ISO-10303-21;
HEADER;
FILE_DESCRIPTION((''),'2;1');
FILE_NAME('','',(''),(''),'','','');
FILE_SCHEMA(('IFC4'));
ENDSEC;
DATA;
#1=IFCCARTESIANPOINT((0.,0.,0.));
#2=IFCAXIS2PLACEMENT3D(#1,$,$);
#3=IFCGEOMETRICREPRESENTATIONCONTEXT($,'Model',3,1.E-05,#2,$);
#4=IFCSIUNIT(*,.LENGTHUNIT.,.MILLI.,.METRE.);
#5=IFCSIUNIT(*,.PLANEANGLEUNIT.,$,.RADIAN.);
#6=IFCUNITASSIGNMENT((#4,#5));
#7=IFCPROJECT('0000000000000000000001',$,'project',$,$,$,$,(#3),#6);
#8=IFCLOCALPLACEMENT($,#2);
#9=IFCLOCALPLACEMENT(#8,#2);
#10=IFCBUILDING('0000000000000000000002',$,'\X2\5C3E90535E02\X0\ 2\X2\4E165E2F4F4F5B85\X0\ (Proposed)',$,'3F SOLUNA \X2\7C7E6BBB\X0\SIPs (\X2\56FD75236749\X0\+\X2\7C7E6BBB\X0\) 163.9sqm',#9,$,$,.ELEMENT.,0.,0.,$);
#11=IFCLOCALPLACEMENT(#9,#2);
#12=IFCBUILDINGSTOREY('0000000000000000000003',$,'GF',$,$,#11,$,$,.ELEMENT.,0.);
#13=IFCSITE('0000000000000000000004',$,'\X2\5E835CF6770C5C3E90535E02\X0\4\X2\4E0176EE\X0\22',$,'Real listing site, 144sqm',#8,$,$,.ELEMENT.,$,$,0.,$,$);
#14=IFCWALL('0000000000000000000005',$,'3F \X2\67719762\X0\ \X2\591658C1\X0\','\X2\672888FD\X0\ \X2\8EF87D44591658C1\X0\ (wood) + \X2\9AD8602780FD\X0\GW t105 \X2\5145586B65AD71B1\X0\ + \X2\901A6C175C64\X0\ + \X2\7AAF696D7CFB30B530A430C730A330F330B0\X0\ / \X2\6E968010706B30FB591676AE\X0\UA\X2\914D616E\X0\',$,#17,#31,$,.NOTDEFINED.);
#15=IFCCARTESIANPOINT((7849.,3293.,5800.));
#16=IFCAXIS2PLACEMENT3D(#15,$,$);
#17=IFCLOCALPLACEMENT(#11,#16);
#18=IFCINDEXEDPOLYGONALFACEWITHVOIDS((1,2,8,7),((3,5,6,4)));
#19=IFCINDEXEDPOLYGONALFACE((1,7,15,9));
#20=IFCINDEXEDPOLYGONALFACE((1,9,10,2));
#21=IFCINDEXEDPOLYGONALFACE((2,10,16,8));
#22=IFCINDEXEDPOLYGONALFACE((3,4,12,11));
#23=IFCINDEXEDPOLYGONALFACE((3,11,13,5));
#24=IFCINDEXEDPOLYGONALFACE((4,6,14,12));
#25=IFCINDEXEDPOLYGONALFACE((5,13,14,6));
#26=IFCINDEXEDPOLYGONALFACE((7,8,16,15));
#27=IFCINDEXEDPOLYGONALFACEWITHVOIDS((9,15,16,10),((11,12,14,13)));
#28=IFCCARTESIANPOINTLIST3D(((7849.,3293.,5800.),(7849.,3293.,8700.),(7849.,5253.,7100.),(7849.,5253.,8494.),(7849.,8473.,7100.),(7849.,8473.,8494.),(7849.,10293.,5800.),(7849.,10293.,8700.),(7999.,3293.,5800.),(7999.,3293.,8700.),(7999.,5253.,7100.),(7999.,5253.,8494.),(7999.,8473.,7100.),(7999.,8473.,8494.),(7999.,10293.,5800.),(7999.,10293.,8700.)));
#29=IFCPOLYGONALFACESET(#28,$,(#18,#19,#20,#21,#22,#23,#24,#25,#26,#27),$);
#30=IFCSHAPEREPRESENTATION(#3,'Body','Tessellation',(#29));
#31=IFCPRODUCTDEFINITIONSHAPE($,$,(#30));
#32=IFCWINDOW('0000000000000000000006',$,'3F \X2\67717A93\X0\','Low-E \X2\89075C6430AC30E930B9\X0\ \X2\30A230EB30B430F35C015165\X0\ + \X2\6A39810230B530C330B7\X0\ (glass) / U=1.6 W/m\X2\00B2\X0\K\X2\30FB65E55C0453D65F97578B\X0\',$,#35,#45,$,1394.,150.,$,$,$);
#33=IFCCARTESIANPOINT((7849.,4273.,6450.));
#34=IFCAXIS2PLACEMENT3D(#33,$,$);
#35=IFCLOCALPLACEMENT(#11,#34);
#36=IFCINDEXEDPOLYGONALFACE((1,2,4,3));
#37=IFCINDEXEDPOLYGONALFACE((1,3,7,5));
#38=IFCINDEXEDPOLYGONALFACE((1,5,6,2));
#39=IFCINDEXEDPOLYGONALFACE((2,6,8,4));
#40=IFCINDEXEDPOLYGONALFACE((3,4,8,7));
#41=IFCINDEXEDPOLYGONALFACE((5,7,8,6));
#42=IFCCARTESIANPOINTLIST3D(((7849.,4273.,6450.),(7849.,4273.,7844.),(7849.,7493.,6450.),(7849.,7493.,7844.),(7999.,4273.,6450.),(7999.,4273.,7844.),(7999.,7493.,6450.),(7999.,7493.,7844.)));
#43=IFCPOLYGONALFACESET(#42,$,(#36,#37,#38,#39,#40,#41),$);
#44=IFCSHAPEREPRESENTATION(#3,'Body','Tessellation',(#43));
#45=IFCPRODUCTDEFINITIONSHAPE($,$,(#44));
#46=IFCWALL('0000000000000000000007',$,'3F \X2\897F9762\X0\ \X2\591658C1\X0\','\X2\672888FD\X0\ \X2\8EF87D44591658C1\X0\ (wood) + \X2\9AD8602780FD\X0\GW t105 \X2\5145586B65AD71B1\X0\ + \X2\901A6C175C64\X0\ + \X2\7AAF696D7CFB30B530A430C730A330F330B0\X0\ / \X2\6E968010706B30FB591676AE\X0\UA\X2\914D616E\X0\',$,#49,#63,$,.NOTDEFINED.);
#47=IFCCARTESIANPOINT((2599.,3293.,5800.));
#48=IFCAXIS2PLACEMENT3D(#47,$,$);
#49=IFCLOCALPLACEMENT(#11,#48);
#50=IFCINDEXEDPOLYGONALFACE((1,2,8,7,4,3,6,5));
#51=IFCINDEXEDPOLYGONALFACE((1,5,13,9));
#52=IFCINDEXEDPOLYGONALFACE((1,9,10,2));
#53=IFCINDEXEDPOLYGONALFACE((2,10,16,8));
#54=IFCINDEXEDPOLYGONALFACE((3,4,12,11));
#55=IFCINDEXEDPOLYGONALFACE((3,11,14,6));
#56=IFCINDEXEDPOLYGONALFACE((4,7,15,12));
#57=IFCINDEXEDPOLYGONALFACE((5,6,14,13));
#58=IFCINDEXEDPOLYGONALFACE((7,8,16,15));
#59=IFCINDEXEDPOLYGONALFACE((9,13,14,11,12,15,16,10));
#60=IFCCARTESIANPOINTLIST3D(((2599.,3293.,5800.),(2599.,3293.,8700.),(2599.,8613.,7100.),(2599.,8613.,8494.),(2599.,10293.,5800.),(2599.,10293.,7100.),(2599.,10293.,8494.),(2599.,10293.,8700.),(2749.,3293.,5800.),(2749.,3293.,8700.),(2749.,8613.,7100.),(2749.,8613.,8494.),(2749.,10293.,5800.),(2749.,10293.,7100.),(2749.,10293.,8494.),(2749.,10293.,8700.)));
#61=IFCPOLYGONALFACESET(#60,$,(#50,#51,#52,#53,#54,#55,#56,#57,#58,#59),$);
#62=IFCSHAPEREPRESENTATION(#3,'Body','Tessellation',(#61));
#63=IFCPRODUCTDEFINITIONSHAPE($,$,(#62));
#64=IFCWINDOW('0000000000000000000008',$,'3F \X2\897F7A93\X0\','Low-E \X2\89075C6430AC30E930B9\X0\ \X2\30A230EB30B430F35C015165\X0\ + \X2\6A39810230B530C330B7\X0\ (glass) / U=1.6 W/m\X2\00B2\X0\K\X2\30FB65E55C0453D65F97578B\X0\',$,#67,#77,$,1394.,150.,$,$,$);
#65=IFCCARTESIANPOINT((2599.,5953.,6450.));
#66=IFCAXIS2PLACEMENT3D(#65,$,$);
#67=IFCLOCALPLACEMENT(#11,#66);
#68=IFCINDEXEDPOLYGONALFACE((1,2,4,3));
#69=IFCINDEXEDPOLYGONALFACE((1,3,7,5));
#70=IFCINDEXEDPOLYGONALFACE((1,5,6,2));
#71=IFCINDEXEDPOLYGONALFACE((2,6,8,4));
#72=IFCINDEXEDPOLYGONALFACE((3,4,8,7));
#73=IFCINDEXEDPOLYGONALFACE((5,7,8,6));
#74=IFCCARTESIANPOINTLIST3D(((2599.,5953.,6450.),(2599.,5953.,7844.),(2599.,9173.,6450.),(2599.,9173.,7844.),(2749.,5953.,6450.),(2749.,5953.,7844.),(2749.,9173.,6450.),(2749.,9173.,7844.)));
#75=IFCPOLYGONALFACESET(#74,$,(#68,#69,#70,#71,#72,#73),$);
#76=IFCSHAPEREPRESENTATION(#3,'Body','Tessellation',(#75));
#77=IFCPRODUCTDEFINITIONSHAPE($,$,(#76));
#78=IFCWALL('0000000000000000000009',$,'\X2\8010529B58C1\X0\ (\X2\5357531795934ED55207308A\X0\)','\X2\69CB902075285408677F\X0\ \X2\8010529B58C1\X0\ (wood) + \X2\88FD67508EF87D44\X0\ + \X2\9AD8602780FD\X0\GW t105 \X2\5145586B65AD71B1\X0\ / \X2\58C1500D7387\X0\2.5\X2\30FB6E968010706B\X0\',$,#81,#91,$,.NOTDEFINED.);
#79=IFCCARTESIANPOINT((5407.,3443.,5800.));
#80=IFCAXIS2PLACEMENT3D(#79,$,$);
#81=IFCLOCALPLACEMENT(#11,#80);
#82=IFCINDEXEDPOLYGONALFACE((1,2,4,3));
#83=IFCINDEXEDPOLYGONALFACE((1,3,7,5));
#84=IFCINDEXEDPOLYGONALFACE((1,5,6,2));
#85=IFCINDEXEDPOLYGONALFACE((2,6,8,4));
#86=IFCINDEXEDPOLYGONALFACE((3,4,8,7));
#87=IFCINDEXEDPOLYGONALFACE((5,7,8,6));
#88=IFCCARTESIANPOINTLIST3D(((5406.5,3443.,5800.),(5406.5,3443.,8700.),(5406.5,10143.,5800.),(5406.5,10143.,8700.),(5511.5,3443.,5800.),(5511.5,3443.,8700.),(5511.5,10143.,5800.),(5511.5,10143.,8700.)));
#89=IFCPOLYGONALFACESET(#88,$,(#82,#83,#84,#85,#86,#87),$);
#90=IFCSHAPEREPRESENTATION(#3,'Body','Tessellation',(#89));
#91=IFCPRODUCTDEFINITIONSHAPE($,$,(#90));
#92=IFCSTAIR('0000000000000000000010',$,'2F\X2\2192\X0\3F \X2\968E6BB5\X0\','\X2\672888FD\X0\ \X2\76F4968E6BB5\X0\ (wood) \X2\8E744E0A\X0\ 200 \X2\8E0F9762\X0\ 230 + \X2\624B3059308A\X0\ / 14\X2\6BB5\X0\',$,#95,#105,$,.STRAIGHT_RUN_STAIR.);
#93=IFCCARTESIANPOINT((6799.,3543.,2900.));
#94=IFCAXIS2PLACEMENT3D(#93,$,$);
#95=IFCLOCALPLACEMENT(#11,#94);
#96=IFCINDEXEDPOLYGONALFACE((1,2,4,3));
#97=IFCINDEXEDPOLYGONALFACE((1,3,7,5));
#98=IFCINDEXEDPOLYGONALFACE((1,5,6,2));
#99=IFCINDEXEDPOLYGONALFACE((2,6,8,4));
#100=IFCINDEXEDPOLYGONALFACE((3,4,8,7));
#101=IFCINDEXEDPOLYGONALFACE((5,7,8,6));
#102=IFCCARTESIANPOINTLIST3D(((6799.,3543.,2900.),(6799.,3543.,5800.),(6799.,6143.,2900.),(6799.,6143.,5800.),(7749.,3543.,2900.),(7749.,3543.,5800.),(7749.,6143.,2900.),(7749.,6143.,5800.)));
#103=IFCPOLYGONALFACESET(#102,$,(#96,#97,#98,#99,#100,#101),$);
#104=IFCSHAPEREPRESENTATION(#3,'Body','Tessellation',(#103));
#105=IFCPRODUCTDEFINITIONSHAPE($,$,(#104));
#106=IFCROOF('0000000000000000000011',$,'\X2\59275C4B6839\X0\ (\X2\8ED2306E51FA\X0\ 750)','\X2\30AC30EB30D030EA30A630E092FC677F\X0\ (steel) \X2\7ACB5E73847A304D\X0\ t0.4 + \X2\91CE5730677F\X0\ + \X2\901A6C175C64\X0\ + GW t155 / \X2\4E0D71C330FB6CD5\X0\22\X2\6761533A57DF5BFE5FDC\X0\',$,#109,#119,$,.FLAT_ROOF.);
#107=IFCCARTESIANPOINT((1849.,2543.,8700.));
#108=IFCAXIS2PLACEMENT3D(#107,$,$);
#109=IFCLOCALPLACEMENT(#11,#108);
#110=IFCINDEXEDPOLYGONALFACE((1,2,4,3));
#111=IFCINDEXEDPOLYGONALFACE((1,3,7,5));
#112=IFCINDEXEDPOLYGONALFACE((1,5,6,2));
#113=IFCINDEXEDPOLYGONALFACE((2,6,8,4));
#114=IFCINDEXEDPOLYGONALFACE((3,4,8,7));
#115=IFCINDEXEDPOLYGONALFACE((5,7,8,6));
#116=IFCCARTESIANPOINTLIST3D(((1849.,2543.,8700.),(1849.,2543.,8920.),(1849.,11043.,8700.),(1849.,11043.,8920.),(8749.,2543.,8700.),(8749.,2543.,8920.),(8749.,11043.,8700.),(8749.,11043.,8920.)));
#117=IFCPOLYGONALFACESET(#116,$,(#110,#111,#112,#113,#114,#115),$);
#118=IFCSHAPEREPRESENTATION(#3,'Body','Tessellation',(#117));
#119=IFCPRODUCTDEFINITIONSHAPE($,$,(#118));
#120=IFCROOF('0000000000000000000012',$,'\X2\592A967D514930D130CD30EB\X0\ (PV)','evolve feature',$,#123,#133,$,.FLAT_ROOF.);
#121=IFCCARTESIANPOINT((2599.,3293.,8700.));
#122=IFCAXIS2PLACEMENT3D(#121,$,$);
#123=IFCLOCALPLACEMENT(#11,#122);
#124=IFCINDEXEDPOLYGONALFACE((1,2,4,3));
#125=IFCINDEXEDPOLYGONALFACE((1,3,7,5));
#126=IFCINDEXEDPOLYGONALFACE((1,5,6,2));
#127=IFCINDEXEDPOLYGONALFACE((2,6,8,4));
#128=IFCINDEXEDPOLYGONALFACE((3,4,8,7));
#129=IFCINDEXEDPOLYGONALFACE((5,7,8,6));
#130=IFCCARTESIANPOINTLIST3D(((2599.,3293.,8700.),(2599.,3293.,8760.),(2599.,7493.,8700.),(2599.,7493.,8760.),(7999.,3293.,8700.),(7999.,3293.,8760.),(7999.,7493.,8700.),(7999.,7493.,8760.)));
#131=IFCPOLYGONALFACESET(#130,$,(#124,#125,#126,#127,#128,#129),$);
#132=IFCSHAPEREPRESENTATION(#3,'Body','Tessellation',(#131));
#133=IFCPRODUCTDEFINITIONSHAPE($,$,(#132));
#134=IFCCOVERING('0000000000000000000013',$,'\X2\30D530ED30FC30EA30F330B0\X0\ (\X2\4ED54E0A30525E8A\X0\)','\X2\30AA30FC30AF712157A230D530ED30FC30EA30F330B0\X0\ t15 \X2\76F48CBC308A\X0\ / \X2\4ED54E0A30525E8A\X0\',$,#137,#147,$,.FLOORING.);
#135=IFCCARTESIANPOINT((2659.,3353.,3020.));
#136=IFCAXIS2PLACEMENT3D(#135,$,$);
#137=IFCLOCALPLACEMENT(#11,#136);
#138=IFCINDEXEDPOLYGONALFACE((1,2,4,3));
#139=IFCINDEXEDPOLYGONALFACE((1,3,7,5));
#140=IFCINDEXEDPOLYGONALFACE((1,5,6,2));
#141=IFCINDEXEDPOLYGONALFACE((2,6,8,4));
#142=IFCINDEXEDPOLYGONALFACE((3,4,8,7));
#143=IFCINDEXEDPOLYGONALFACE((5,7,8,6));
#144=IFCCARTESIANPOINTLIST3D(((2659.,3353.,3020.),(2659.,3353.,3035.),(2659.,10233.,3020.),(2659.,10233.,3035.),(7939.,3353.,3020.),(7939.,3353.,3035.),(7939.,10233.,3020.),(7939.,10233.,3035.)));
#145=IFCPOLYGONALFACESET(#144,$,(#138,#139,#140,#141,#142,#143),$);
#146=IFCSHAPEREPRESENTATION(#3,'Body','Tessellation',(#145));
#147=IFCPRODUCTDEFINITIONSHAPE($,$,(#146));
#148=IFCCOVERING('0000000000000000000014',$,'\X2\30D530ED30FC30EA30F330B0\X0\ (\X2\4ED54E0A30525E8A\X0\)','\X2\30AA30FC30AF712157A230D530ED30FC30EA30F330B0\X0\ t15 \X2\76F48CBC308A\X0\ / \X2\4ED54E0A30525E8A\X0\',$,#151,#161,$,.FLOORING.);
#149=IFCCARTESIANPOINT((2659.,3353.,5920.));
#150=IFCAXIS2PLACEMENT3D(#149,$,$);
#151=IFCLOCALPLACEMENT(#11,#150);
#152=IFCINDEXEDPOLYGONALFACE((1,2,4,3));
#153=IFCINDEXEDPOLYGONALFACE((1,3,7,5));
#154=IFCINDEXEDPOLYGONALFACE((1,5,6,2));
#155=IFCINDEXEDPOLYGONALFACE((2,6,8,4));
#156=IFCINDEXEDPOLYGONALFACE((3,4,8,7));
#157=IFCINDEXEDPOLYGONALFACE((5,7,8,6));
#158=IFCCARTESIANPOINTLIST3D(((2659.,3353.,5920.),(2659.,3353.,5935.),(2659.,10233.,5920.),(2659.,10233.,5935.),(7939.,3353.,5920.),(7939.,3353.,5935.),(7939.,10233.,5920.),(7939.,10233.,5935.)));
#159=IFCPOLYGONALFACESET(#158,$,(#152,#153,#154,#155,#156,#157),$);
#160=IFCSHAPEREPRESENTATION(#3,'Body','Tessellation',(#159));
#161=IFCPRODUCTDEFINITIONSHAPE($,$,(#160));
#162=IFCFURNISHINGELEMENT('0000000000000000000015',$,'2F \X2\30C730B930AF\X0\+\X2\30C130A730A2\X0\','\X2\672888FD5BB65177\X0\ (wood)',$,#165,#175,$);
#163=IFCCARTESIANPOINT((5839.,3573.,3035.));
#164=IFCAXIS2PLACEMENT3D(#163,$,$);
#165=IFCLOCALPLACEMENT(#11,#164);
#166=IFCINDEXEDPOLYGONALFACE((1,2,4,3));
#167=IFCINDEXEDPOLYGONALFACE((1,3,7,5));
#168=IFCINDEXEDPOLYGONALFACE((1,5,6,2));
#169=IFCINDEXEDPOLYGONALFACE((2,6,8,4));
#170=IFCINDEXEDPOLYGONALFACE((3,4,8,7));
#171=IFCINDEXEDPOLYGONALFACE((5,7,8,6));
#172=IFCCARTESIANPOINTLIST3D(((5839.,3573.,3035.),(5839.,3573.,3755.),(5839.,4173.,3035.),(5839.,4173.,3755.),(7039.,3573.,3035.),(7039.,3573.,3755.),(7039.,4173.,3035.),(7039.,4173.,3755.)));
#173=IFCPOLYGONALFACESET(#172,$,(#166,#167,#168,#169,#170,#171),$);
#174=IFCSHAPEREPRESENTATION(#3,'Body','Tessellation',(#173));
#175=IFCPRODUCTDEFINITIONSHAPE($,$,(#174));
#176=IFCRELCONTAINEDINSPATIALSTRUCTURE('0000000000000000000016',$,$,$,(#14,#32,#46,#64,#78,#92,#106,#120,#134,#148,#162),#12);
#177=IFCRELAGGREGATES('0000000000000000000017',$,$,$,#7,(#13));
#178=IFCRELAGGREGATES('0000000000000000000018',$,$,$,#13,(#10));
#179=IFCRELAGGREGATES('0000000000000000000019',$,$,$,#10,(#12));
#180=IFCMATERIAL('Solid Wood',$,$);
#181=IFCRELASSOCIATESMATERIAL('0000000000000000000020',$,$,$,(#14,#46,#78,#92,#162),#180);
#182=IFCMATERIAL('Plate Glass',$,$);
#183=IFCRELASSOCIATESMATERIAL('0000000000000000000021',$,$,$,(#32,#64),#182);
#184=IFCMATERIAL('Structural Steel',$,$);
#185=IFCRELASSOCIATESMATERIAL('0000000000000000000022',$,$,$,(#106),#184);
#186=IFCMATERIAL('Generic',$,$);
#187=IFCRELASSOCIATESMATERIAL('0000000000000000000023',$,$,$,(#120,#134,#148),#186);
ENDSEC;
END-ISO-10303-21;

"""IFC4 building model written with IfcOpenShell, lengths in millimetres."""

from ifc_helpers import new_model, si_unit, frame, frame_2d, origin, place, context, project, spatial, rectangle, extrude, material, element, fill, save


model = new_model("IFC4")

# Units and contexts
model_context = context("Model", 3, precision=1e-05, world=origin())
ifc_project = project(units=[si_unit("LENGTHUNIT", "METRE", prefix="MILLI"), si_unit("PLANEANGLEUNIT", "RADIAN")], contexts=[model_context])

# Site, building, storey
site_placement = place(None, origin())
site = spatial("IfcSite", under=ifc_project, at=site_placement, Name="広島県尾道市4丁目22", ObjectType="Real listing site, 144sqm", CompositionType="ELEMENT", RefElevation=0.0)
building_placement = place(site_placement, origin())
building = spatial("IfcBuilding", under=site, at=building_placement, Name="尾道市 2世帯住宅 (Proposed)", ObjectType="3F SOLUNA 籾殻SIPs (国産杉+籾殻) 163.9sqm", CompositionType="ELEMENT", ElevationOfRefHeight=0.0, ElevationOfTerrain=0.0)
storey_placement = place(building_placement, origin())
storey = spatial("IfcBuildingStorey", under=building, at=storey_placement, Name="GF", CompositionType="ELEMENT", Elevation=0.0)

# Shared definitions
ifc_material_1 = material(Name="Solid Wood")

# Shared definitions
ifc_material_2 = material(Name="Plate Glass")

# Shared definitions
ifc_material_3 = material(Name="Generic")

# Walls, openings, windows
wall_1_placement = place(storey_placement, frame((7849.0, 3293.0, 5800.0)))
wall_1 = element("IfcWall", 1, at=wall_1_placement, inside=storey, material=ifc_material_1, Name="3F 東面 外壁", Description="木製 軸組外壁 (wood) + 高性能GW t105 充填断熱 + 通気層 + 窯業系サイディング / 準耐火・外皮UA配慮", PredefinedType="NOTDEFINED", context=model_context, shape_type="SweptSolid", body=[
    extrude(rectangle(XDim=150.0, YDim=7000.0, at=frame_2d((75.0, 3500.0))), frame((7849.0, 3293.0, 5800.0)), (0.0, 0.0, 1.0), 2900.0),
])
opening_1_placement = place(storey_placement, frame((7849.0, 4273.0, 6450.0)))
opening_1 = element("IfcOpeningElement", 2, at=opening_1_placement, cuts=wall_1, PredefinedType="NOTDEFINED", context=model_context, shape_type="SweptSolid", body=[
    extrude(rectangle(XDim=150.0, YDim=3220.0, at=frame_2d((75.0, 1610.0))), frame((7849.0, 4273.0, 6450.0)), (0.0, 0.0, 1.0), 1394.0),
])
window_1_placement = place(storey_placement, frame((7849.0, 4273.0, 6450.0)))
window_1 = element("IfcWindow", 3, at=window_1_placement, inside=storey, material=ifc_material_2, Name="3F 東窓", Description="Low-E 複層ガラス アルゴン封入 + 樹脂サッシ (glass) / U=1.6 W/m²K・日射取得型", OverallHeight=1394.0, OverallWidth=150.0, context=model_context, shape_type="SweptSolid", body=[
    extrude(rectangle(XDim=150.0, YDim=3220.0, at=frame_2d((75.0, 1610.0))), frame((7849.0, 4273.0, 6450.0)), (0.0, 0.0, 1.0), 1394.0),
])
fill(opening_1, window_1)
wall_2_placement = place(storey_placement, frame((2599.0, 3293.0, 5800.0)))
wall_2 = element("IfcWall", 4, at=wall_2_placement, inside=storey, material=ifc_material_1, Name="3F 西面 外壁", Description="木製 軸組外壁 (wood) + 高性能GW t105 充填断熱 + 通気層 + 窯業系サイディング / 準耐火・外皮UA配慮", PredefinedType="NOTDEFINED", context=model_context, shape_type="SweptSolid", body=[
    extrude(rectangle(XDim=150.0, YDim=7000.0, at=frame_2d((75.0, 3500.0))), frame((2599.0, 3293.0, 5800.0)), (0.0, 0.0, 1.0), 2900.0),
])
opening_2_placement = place(storey_placement, frame((2599.0, 5953.0, 6450.0)))
opening_2 = element("IfcOpeningElement", 5, at=opening_2_placement, cuts=wall_2, PredefinedType="NOTDEFINED", context=model_context, shape_type="SweptSolid", body=[
    extrude(rectangle(XDim=150.0, YDim=3220.0, at=frame_2d((75.0, 1610.0))), frame((2599.0, 5953.0, 6450.0)), (0.0, 0.0, 1.0), 1394.0),
])
window_2_placement = place(storey_placement, frame((2599.0, 5953.0, 6450.0)))
window_2 = element("IfcWindow", 6, at=window_2_placement, inside=storey, material=ifc_material_2, Name="3F 西窓", Description="Low-E 複層ガラス アルゴン封入 + 樹脂サッシ (glass) / U=1.6 W/m²K・日射取得型", OverallHeight=1394.0, OverallWidth=150.0, context=model_context, shape_type="SweptSolid", body=[
    extrude(rectangle(XDim=150.0, YDim=3220.0, at=frame_2d((75.0, 1610.0))), frame((2599.0, 5953.0, 6450.0)), (0.0, 0.0, 1.0), 1394.0),
])
fill(opening_2, window_2)

# Wall
wall_3_placement = place(storey_placement, frame((5407.0, 3443.0, 5800.0)))
element("IfcWall", 7, at=wall_3_placement, inside=storey, material=ifc_material_1, Name="耐力壁 (南北間仕切り)", Description="構造用合板 耐力壁 (wood) + 製材軸組 + 高性能GW t105 充填断熱 / 壁倍率2.5・準耐火", PredefinedType="NOTDEFINED", context=model_context, shape_type="SweptSolid", body=[
    extrude(rectangle(XDim=105.0, YDim=6700.0, at=frame_2d((52.0, 3350.0))), frame((5407.0, 3443.0, 5800.0)), (0.0, 0.0, 1.0), 2900.0),
])

# Stair
stair_placement = place(storey_placement, frame((6799.0, 3543.0, 2900.0)))
element("IfcStair", 8, at=stair_placement, inside=storey, material=ifc_material_1, Name="2F→3F 階段", Description="木製 直階段 (wood) 蹴上 200 踏面 230 + 手すり / 14段", PredefinedType="STRAIGHT_RUN_STAIR", context=model_context, shape_type="SweptSolid", body=[
    extrude(rectangle(XDim=950.0, YDim=2600.0, at=frame_2d((475.0, 1300.0))), frame((6799.0, 3543.0, 2900.0)), (0.0, 0.0, 1.0), 2900.0),
])

# Roofs
ifc_material_4 = material(Name="Structural Steel")
roof_1_placement = place(storey_placement, frame((1849.0, 2543.0, 8700.0)))
element("IfcRoof", 9, at=roof_1_placement, inside=storey, material=ifc_material_4, Name="大屋根 (軒の出 750)", Description="ガルバリウム鋼板 (steel) 立平葺き t0.4 + 野地板 + 通気層 + GW t155 / 不燃・法22条区域対応", PredefinedType="FLAT_ROOF", context=model_context, shape_type="SweptSolid", body=[
    extrude(rectangle(XDim=6900.0, YDim=8500.0, at=frame_2d((3450.0, 4250.0))), frame((1849.0, 2543.0, 8700.0)), (0.0, 0.0, 1.0), 220.0),
])
roof_2_placement = place(storey_placement, frame((2599.0, 3293.0, 8700.0)))
element("IfcRoof", 10, at=roof_2_placement, inside=storey, material=ifc_material_3, Name="太陽光パネル (PV)", Description="evolve feature", PredefinedType="FLAT_ROOF", context=model_context, shape_type="SweptSolid", body=[
    extrude(rectangle(XDim=5400.0, YDim=4200.0, at=frame_2d((2700.0, 2100.0))), frame((2599.0, 3293.0, 8700.0)), (0.0, 0.0, 1.0), 60.0),
])

# Coverings
covering_1_placement = place(storey_placement, frame((2659.0, 3353.0, 3020.0)))
element("IfcCovering", 11, at=covering_1_placement, inside=storey, material=ifc_material_3, Name="フローリング (仕上げ床)", Description="オーク無垢フローリング t15 直貼り / 仕上げ床", PredefinedType="FLOORING", context=model_context, shape_type="SweptSolid", body=[
    extrude(rectangle(XDim=5280.0, YDim=6880.0, at=frame_2d((2640.0, 3440.0))), frame((2659.0, 3353.0, 3020.0)), (0.0, 0.0, 1.0), 15.0),
])
covering_2_placement = place(storey_placement, frame((2659.0, 3353.0, 5920.0)))
element("IfcCovering", 12, at=covering_2_placement, inside=storey, material=ifc_material_3, Name="フローリング (仕上げ床)", Description="オーク無垢フローリング t15 直貼り / 仕上げ床", PredefinedType="FLOORING", context=model_context, shape_type="SweptSolid", body=[
    extrude(rectangle(XDim=5280.0, YDim=6880.0, at=frame_2d((2640.0, 3440.0))), frame((2659.0, 3353.0, 5920.0)), (0.0, 0.0, 1.0), 15.0),
])

# Furnishing element
furnishing_placement = place(storey_placement, frame((5839.0, 3573.0, 3035.0)))
element("IfcFurnishingElement", 13, at=furnishing_placement, inside=storey, material=ifc_material_1, Name="2F デスク+チェア", Description="木製家具 (wood)", context=model_context, shape_type="SweptSolid", body=[
    extrude(rectangle(XDim=1200.0, YDim=600.0, at=frame_2d((600.0, 300.0))), frame((5839.0, 3573.0, 3035.0)), (0.0, 0.0, 1.0), 720.0),
])

save(model, "model.ifc")
